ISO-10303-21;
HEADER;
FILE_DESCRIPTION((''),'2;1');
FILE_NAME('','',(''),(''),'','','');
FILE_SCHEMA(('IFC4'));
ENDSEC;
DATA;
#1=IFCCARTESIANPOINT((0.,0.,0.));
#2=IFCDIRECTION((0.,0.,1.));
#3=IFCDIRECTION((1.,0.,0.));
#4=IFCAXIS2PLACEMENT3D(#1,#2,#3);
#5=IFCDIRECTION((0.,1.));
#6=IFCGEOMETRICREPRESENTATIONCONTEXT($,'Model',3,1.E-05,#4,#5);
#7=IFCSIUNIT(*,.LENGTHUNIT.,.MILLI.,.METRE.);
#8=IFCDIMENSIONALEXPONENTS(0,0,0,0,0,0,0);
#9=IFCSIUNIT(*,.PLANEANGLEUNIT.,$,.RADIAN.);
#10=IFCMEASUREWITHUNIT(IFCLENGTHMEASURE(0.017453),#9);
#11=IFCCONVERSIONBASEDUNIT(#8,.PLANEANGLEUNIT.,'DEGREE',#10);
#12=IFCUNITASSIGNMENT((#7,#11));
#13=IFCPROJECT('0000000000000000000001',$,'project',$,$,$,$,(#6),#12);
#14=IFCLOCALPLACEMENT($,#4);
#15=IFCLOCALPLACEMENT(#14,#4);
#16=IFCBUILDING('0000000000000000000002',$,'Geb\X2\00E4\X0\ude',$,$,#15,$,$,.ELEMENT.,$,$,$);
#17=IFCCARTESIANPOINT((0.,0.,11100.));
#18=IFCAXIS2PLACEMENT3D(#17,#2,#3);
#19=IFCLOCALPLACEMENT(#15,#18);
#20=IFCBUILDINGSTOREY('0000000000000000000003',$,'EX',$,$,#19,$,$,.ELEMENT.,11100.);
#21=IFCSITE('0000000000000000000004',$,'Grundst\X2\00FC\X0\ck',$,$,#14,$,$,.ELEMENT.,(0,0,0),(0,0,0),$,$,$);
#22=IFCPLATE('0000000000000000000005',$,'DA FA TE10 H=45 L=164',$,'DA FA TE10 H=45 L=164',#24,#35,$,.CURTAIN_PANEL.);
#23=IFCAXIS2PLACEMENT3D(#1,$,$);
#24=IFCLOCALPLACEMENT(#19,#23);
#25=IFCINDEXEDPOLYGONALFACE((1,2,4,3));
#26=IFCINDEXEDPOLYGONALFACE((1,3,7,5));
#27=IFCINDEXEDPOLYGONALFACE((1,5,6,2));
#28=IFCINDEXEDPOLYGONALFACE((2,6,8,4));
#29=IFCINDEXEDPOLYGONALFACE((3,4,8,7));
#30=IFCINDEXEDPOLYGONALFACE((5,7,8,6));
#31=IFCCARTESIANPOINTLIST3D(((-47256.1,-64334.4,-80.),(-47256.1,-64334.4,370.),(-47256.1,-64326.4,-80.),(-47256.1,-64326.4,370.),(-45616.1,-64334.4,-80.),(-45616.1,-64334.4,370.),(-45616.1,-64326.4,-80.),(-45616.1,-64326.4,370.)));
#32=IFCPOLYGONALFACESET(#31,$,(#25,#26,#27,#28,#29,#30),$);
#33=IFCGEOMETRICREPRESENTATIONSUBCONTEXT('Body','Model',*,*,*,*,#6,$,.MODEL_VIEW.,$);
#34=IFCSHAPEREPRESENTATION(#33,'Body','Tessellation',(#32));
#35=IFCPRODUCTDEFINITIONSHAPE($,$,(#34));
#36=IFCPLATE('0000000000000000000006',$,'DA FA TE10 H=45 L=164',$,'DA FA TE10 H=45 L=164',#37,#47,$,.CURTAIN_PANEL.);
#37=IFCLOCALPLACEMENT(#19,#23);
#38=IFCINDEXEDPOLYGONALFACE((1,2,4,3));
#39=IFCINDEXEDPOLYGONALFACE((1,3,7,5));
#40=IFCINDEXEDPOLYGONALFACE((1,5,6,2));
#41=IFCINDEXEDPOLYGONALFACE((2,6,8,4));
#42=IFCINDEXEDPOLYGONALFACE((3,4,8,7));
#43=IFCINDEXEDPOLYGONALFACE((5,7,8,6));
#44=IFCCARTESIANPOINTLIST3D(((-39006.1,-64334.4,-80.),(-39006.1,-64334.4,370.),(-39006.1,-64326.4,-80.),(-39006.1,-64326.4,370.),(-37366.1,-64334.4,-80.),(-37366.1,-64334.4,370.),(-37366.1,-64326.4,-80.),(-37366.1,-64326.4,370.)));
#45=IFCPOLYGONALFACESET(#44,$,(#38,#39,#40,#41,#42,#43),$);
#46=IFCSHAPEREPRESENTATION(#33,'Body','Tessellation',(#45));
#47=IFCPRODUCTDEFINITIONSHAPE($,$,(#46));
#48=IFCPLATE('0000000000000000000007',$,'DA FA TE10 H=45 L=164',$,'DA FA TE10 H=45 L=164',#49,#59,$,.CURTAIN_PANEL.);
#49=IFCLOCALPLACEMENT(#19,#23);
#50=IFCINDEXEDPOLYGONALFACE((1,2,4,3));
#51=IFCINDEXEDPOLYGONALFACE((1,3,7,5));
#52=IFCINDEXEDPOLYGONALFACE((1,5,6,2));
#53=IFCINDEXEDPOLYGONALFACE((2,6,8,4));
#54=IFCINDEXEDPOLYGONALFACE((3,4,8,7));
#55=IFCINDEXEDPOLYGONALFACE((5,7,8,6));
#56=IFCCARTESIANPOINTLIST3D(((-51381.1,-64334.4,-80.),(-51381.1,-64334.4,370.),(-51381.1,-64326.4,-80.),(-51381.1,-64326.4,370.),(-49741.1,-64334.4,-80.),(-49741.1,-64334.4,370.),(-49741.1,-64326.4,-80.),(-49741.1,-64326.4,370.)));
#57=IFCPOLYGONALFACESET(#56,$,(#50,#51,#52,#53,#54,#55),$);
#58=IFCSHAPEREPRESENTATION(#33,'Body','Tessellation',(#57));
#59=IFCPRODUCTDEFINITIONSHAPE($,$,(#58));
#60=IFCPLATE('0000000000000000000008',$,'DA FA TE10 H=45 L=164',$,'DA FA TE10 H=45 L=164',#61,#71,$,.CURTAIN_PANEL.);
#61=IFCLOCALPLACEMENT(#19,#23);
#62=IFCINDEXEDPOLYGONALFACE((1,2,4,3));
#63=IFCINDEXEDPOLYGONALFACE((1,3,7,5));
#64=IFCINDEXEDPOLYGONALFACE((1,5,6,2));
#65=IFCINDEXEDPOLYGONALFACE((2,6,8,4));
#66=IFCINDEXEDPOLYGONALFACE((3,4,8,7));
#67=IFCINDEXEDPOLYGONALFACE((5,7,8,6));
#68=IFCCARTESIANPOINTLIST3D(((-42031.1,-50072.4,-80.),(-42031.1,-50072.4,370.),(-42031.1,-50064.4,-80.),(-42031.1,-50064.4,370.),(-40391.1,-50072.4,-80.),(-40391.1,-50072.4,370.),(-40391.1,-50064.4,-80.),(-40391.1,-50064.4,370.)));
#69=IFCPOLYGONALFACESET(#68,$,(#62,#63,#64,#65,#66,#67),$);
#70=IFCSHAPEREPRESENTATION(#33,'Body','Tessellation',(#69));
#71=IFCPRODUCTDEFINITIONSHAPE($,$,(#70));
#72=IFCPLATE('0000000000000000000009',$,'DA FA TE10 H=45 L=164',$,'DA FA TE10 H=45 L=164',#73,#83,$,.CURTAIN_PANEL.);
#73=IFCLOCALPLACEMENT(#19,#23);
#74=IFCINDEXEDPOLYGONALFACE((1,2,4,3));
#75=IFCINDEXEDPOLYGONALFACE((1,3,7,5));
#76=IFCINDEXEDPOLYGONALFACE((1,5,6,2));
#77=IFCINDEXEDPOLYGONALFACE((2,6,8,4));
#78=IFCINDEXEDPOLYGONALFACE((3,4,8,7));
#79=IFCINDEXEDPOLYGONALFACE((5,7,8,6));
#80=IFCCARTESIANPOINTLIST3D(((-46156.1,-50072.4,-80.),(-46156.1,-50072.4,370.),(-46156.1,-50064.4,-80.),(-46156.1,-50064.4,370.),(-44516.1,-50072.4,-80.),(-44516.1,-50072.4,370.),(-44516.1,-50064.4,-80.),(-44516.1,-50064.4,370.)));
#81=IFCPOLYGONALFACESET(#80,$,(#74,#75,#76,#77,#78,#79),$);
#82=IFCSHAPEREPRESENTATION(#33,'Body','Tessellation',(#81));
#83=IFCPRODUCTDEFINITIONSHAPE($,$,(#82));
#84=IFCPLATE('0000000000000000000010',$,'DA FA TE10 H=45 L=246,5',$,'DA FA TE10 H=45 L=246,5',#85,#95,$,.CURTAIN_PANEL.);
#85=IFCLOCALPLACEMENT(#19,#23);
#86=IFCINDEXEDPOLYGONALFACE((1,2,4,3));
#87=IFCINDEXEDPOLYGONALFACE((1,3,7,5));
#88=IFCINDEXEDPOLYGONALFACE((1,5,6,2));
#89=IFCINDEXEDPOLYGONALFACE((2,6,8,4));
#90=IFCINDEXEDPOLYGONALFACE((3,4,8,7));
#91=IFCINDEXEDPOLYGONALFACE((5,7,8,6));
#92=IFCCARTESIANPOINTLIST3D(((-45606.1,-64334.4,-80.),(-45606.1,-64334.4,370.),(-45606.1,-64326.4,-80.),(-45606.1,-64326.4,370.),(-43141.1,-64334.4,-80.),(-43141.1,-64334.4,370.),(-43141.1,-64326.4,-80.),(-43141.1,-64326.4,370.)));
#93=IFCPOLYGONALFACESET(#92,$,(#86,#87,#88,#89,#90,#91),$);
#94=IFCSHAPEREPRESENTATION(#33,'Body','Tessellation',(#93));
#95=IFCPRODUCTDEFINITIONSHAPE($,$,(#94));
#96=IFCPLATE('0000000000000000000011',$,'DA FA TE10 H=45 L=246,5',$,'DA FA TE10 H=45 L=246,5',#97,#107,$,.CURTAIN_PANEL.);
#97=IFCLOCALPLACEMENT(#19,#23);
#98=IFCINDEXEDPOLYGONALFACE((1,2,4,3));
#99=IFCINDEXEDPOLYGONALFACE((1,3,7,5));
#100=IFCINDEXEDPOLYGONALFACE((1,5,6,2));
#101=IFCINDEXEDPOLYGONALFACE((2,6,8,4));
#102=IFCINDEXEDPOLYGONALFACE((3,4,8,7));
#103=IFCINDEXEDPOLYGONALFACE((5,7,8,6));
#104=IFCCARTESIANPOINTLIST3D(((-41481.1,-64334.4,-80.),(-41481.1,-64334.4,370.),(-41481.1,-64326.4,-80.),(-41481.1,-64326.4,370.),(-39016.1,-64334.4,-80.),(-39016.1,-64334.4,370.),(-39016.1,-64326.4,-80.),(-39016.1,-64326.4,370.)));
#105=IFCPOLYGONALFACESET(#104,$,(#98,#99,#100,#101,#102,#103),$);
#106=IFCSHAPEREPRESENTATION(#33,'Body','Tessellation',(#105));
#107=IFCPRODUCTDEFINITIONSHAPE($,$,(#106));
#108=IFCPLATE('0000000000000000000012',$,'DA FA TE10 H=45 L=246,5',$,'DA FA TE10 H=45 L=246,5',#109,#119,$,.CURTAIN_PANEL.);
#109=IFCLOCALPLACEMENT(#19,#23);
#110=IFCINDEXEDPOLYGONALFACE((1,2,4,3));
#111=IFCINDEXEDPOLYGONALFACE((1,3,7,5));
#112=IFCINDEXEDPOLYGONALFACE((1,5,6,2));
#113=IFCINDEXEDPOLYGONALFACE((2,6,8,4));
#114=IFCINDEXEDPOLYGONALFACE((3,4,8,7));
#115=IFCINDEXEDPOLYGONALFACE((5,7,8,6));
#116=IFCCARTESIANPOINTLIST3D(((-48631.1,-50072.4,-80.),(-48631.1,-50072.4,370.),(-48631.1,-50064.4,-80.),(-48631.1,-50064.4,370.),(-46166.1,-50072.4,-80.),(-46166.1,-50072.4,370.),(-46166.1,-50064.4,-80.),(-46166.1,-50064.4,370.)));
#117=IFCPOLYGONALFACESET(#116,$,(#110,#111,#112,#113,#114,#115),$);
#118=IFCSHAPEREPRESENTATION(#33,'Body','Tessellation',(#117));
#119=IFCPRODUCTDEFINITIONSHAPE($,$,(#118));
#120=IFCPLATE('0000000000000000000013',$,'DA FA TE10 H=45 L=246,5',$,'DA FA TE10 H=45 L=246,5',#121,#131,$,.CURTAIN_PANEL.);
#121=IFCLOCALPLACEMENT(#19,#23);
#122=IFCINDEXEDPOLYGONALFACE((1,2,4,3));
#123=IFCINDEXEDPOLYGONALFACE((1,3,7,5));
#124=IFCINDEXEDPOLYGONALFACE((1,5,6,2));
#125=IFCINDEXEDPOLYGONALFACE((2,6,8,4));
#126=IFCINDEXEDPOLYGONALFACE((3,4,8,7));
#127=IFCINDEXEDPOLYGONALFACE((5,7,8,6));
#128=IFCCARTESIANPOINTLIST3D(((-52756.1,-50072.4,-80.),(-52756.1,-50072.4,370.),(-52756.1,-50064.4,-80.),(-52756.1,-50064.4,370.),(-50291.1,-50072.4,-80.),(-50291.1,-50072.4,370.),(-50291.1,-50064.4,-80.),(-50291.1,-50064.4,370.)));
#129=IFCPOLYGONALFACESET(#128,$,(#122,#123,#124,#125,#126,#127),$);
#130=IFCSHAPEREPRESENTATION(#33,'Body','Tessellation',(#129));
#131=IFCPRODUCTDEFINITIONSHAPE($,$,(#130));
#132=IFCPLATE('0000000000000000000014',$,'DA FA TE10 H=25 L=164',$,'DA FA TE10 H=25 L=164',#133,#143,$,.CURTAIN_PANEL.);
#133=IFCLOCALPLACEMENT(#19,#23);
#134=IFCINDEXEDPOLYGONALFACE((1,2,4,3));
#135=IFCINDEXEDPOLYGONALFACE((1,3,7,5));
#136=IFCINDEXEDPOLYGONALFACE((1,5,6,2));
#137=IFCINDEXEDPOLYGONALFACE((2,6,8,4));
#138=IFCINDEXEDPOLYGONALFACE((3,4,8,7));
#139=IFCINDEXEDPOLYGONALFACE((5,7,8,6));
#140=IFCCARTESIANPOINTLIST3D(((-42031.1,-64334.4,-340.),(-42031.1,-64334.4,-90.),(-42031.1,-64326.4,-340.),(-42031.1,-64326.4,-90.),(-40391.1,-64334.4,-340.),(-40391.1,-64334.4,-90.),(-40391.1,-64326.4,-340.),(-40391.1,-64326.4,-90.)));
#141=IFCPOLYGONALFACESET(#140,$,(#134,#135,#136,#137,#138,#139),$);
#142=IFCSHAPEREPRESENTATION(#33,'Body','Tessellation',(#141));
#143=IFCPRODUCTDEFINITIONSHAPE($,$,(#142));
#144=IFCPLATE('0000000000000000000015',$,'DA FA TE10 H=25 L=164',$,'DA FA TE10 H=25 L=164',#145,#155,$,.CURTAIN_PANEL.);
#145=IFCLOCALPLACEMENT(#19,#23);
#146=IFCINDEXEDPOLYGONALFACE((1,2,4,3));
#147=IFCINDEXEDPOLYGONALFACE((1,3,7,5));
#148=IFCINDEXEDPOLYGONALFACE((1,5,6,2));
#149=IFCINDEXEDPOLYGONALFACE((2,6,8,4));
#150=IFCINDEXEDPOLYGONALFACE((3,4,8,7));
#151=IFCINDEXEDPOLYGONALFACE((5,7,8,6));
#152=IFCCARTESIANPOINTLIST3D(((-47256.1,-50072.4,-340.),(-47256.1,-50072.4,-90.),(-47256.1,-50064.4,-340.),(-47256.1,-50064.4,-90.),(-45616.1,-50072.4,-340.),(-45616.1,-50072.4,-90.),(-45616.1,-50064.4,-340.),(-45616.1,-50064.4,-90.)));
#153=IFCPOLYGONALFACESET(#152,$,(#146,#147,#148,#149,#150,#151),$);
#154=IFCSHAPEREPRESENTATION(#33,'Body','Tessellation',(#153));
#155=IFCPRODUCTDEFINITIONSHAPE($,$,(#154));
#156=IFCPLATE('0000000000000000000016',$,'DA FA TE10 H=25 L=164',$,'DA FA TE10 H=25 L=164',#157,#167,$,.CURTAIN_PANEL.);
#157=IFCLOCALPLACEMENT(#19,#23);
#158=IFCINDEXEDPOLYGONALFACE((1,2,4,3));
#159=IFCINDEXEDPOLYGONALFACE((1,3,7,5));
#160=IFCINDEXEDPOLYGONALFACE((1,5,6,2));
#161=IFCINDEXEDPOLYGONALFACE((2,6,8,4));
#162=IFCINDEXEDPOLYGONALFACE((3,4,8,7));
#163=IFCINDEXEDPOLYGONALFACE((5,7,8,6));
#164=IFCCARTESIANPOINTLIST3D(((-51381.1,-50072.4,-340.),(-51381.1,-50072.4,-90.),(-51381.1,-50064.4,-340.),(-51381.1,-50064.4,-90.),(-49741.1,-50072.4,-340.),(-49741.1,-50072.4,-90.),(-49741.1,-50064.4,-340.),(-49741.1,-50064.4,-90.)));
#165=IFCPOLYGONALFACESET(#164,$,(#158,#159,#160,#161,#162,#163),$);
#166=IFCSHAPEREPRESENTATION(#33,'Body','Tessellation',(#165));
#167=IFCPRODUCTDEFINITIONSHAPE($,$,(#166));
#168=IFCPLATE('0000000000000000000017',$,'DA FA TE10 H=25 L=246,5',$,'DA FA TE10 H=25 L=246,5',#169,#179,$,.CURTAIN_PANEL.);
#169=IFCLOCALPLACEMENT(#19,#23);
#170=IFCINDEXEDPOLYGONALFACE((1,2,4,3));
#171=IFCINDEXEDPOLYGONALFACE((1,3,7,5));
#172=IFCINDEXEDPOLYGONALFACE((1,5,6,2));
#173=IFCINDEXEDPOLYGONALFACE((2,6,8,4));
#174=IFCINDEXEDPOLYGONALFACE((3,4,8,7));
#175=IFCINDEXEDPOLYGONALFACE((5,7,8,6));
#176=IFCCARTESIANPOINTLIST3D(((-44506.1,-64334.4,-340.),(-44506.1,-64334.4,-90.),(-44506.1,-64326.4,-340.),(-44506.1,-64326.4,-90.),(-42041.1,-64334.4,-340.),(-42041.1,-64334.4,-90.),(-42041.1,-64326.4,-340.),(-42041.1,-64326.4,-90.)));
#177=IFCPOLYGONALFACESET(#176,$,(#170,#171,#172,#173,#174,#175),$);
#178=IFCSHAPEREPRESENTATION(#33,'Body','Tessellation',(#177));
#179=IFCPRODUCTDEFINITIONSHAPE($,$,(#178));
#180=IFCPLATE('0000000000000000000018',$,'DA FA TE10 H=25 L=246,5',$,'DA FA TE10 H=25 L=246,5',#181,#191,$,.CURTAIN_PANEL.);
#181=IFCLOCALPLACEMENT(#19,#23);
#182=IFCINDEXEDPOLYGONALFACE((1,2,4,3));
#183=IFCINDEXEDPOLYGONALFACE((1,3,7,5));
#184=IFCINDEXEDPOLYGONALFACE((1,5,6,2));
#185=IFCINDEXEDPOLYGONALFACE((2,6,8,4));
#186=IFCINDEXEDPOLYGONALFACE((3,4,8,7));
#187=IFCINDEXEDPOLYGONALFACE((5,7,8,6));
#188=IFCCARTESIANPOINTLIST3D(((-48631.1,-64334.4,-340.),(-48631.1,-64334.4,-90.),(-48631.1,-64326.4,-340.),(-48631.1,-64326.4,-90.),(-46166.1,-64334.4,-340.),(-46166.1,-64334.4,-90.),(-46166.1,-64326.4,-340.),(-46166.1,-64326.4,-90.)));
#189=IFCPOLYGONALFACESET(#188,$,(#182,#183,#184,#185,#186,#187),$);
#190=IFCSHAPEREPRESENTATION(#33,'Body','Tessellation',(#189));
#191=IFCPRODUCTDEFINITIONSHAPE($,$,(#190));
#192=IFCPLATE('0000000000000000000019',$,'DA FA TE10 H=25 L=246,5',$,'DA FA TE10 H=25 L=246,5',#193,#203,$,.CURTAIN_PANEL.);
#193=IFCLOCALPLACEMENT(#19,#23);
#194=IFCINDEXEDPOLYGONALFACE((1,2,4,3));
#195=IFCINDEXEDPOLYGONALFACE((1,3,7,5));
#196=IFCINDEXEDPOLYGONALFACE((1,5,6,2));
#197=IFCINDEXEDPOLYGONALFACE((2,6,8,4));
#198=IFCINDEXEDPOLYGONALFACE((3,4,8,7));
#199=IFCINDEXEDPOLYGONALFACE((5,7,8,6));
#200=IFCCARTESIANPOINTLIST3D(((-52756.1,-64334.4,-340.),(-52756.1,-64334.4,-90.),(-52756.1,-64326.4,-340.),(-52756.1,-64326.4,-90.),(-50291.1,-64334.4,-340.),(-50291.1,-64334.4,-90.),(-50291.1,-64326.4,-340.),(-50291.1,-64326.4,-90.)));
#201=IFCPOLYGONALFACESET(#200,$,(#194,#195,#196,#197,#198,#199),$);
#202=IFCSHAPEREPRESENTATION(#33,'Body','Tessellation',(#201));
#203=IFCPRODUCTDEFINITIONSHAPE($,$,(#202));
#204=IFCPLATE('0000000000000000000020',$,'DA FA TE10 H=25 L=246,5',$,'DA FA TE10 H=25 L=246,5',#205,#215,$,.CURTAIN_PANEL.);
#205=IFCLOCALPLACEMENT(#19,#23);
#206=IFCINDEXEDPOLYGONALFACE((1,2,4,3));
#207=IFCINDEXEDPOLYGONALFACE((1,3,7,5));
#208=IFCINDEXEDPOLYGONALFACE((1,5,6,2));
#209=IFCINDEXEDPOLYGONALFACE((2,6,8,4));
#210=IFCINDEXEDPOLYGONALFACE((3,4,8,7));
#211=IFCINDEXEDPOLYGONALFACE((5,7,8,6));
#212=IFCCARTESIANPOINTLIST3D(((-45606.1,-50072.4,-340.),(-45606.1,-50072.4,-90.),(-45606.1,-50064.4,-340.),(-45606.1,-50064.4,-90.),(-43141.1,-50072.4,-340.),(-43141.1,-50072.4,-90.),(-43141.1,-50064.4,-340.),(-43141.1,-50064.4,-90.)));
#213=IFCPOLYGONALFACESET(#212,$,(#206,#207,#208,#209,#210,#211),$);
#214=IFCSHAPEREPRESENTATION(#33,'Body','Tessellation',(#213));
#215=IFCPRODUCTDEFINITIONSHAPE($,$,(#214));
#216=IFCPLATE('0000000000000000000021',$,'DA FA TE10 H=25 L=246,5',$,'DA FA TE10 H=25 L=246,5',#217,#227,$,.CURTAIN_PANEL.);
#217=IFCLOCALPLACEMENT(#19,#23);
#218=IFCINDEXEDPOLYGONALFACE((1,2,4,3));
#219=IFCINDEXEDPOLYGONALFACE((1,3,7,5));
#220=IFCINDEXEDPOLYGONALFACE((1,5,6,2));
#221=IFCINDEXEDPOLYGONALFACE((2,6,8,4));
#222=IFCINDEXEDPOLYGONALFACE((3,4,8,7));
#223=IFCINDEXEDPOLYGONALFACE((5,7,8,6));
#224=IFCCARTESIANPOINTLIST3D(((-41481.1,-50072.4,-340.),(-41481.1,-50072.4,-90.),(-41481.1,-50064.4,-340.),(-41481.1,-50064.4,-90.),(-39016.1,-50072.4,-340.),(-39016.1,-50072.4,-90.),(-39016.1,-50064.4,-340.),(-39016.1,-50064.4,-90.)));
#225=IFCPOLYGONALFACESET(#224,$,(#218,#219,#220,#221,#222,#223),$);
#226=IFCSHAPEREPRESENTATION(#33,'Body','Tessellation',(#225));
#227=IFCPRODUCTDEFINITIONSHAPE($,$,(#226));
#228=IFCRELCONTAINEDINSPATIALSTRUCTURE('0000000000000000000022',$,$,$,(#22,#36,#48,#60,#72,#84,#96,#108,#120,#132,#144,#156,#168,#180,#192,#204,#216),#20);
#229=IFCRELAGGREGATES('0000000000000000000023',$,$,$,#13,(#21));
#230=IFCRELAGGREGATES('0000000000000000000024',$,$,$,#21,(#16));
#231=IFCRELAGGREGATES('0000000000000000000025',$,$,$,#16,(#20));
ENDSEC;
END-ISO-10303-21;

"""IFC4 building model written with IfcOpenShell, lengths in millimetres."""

from ifc_helpers import new_model, entity, si_unit, converted_unit, direction, frame, origin_with_axes, place, context, subcontext, project, spatial, line, indexed_curve, outline, extrude, source, transform, mapped, element, save


model = new_model("IFC4")

# Units and contexts
model_context = context("Model", 3, precision=1e-05, world=origin_with_axes(), true_north=direction((0.0, 1.0)))
body_context = subcontext(model_context, "Body", "Model", "MODEL_VIEW")
ifc_project = project(units=[si_unit("LENGTHUNIT", "METRE", prefix="MILLI"), converted_unit("PLANEANGLEUNIT", "DEGREE", entity("IfcLengthMeasure", 0.017453), si_unit("PLANEANGLEUNIT", "RADIAN"), dimensions=[0, 0, 0, 0, 0, 0, 0])], contexts=[model_context])

# Site, building, storey
site_placement = place(None, origin_with_axes())
site = spatial("IfcSite", under=ifc_project, at=site_placement, Name="Grundstück", CompositionType="ELEMENT", RefLatitude=(0, 0, 0), RefLongitude=(0, 0, 0))
building_placement = place(site_placement, origin_with_axes())
building = spatial("IfcBuilding", under=site, at=building_placement, Name="Gebäude", CompositionType="ELEMENT")
storey_placement = place(building_placement, frame((0.0, 0.0, 11100.0), z_axis=(0.0, 0.0, 1.0), x_axis=(1.0, 0.0, 0.0)))
storey = spatial("IfcBuildingStorey", under=building, at=storey_placement, Name="EX", CompositionType="ELEMENT", Elevation=11100.0)

# Plates
shared_shape_1 = source(origin_with_axes(), body_context, "Body", "SweptSolid", [
    extrude(outline(indexed_curve([(-820.0, 0.0), (820.0, 0.0), (820.0, 8.0), (-820.0, 8.0)], segments=[line(1, 2), line(2, 3), line(3, 4), line(4, 1)])), frame((0.0, 0.0, 450.0), z_axis=(0.0, 0.0, 1.0), x_axis=(1.0, 0.0, 0.0)), (0.0, 0.0, -1.0), 450.0),
])
for number, where, z_axis, x_axis, name in (
    (1, (-46436.1, -64334.4, -80.0), (0.0, 0.0, 1.0), (1.0, 0.0, 0.0), "DA FA TE10 H=45 L=164"),
    (2, (-38186.1, -64334.4, -80.0), (0.0, 0.0, 1.0), (1.0, 0.0, 0.0), "DA FA TE10 H=45 L=164"),
    (3, (-50561.1, -64334.4, -80.0), (0.0, 0.0, 1.0), (1.0, 0.0, 0.0), "DA FA TE10 H=45 L=164"),
    (4, (-41211.1, -50064.4, -80.0), (0.0, 0.0, 1.0), (-1.0, 0.0, 0.0), "DA FA TE10 H=45 L=164"),
    (5, (-45336.1, -50064.4, -80.0), (0.0, 0.0, 1.0), (-1.0, 0.0, 0.0), "DA FA TE10 H=45 L=164"),
):
    element("IfcPlate", number, at=place(storey_placement, frame(where, z_axis=z_axis, x_axis=x_axis)), inside=storey, Name=name, ObjectType="DA FA TE10 H=45 L=164", PredefinedType="CURTAIN_PANEL", context=body_context, shape_type="MappedRepresentation", body=[
        mapped(shared_shape_1, transform((0.0, 0.0, 0.0), x_axis=(1.0, 0.0, 0.0), y_axis=(0.0, 1.0, 0.0), z_axis=(0.0, 0.0, 1.0), scale=1.0)),
    ])
shared_shape_2 = source(origin_with_axes(), body_context, "Body", "SweptSolid", [
    extrude(outline(indexed_curve([(-1232.5, 0.0), (1232.5, 0.0), (1232.5, 8.0), (-1232.5, 8.0)], segments=[line(1, 2), line(2, 3), line(3, 4), line(4, 1)])), frame((0.0, 0.0, 450.0), z_axis=(0.0, 0.0, 1.0), x_axis=(1.0, 0.0, 0.0)), (0.0, 0.0, -1.0), 450.0),
])
for number, where, z_axis, x_axis, name in (
    (6, (-44373.6, -64334.4, -80.0), (0.0, 0.0, 1.0), (1.0, 0.0, 0.0), "DA FA TE10 H=45 L=246,5"),
    (7, (-40248.6, -64334.4, -80.0), (0.0, 0.0, 1.0), (1.0, 0.0, 0.0), "DA FA TE10 H=45 L=246,5"),
    (8, (-47398.6, -50064.4, -80.0), (0.0, 0.0, 1.0), (-1.0, 0.0, 0.0), "DA FA TE10 H=45 L=246,5"),
    (9, (-51523.6, -50064.4, -80.0), (0.0, 0.0, 1.0), (-1.0, 0.0, 0.0), "DA FA TE10 H=45 L=246,5"),
):
    element("IfcPlate", number, at=place(storey_placement, frame(where, z_axis=z_axis, x_axis=x_axis)), inside=storey, Name=name, ObjectType="DA FA TE10 H=45 L=246,5", PredefinedType="CURTAIN_PANEL", context=body_context, shape_type="MappedRepresentation", body=[
        mapped(shared_shape_2, transform((0.0, 0.0, 0.0), x_axis=(1.0, 0.0, 0.0), y_axis=(0.0, 1.0, 0.0), z_axis=(0.0, 0.0, 1.0), scale=1.0)),
    ])
shared_shape_3 = source(origin_with_axes(), body_context, "Body", "SweptSolid", [
    extrude(outline(indexed_curve([(-820.0, 0.0), (820.0, 0.0), (820.0, 8.0), (-820.0, 8.0)], segments=[line(1, 2), line(2, 3), line(3, 4), line(4, 1)])), frame((0.0, 0.0, 250.0), z_axis=(0.0, 0.0, 1.0), x_axis=(1.0, 0.0, 0.0)), (0.0, 0.0, -1.0), 250.0),
])
for number, where, z_axis, x_axis, name in (
    (10, (-41211.1, -64334.4, -340.0), (0.0, 0.0, 1.0), (1.0, 0.0, 0.0), "DA FA TE10 H=25 L=164"),
    (11, (-46436.1, -50064.4, -340.0), (0.0, 0.0, 1.0), (-1.0, 0.0, 0.0), "DA FA TE10 H=25 L=164"),
    (12, (-50561.1, -50064.4, -340.0), (0.0, 0.0, 1.0), (-1.0, 0.0, 0.0), "DA FA TE10 H=25 L=164"),
):
    element("IfcPlate", number, at=place(storey_placement, frame(where, z_axis=z_axis, x_axis=x_axis)), inside=storey, Name=name, ObjectType="DA FA TE10 H=25 L=164", PredefinedType="CURTAIN_PANEL", context=body_context, shape_type="MappedRepresentation", body=[
        mapped(shared_shape_3, transform((0.0, 0.0, 0.0), x_axis=(1.0, 0.0, 0.0), y_axis=(0.0, 1.0, 0.0), z_axis=(0.0, 0.0, 1.0), scale=1.0)),
    ])
shared_shape_4 = source(origin_with_axes(), body_context, "Body", "SweptSolid", [
    extrude(outline(indexed_curve([(-1232.5, 0.0), (1232.5, 0.0), (1232.5, 8.0), (-1232.5, 8.0)], segments=[line(1, 2), line(2, 3), line(3, 4), line(4, 1)])), frame((0.0, 0.0, 250.0), z_axis=(0.0, 0.0, 1.0), x_axis=(1.0, 0.0, 0.0)), (0.0, 0.0, -1.0), 250.0),
])
for number, where, z_axis, x_axis, name in (
    (13, (-43273.6, -64334.4, -340.0), (0.0, 0.0, 1.0), (1.0, 0.0, 0.0), "DA FA TE10 H=25 L=246,5"),
    (14, (-47398.6, -64334.4, -340.0), (0.0, 0.0, 1.0), (1.0, 0.0, 0.0), "DA FA TE10 H=25 L=246,5"),
    (15, (-51523.6, -64334.4, -340.0), (0.0, 0.0, 1.0), (1.0, 0.0, 0.0), "DA FA TE10 H=25 L=246,5"),
    (16, (-44373.6, -50064.4, -340.0), (0.0, 0.0, 1.0), (-1.0, 0.0, 0.0), "DA FA TE10 H=25 L=246,5"),
    (17, (-40248.6, -50064.4, -340.0), (0.0, 0.0, 1.0), (-1.0, 0.0, 0.0), "DA FA TE10 H=25 L=246,5"),
):
    element("IfcPlate", number, at=place(storey_placement, frame(where, z_axis=z_axis, x_axis=x_axis)), inside=storey, Name=name, ObjectType="DA FA TE10 H=25 L=246,5", PredefinedType="CURTAIN_PANEL", context=body_context, shape_type="MappedRepresentation", body=[
        mapped(shared_shape_4, transform((0.0, 0.0, 0.0), x_axis=(1.0, 0.0, 0.0), y_axis=(0.0, 1.0, 0.0), z_axis=(0.0, 0.0, 1.0), scale=1.0)),
    ])

save(model, "model.ifc")
